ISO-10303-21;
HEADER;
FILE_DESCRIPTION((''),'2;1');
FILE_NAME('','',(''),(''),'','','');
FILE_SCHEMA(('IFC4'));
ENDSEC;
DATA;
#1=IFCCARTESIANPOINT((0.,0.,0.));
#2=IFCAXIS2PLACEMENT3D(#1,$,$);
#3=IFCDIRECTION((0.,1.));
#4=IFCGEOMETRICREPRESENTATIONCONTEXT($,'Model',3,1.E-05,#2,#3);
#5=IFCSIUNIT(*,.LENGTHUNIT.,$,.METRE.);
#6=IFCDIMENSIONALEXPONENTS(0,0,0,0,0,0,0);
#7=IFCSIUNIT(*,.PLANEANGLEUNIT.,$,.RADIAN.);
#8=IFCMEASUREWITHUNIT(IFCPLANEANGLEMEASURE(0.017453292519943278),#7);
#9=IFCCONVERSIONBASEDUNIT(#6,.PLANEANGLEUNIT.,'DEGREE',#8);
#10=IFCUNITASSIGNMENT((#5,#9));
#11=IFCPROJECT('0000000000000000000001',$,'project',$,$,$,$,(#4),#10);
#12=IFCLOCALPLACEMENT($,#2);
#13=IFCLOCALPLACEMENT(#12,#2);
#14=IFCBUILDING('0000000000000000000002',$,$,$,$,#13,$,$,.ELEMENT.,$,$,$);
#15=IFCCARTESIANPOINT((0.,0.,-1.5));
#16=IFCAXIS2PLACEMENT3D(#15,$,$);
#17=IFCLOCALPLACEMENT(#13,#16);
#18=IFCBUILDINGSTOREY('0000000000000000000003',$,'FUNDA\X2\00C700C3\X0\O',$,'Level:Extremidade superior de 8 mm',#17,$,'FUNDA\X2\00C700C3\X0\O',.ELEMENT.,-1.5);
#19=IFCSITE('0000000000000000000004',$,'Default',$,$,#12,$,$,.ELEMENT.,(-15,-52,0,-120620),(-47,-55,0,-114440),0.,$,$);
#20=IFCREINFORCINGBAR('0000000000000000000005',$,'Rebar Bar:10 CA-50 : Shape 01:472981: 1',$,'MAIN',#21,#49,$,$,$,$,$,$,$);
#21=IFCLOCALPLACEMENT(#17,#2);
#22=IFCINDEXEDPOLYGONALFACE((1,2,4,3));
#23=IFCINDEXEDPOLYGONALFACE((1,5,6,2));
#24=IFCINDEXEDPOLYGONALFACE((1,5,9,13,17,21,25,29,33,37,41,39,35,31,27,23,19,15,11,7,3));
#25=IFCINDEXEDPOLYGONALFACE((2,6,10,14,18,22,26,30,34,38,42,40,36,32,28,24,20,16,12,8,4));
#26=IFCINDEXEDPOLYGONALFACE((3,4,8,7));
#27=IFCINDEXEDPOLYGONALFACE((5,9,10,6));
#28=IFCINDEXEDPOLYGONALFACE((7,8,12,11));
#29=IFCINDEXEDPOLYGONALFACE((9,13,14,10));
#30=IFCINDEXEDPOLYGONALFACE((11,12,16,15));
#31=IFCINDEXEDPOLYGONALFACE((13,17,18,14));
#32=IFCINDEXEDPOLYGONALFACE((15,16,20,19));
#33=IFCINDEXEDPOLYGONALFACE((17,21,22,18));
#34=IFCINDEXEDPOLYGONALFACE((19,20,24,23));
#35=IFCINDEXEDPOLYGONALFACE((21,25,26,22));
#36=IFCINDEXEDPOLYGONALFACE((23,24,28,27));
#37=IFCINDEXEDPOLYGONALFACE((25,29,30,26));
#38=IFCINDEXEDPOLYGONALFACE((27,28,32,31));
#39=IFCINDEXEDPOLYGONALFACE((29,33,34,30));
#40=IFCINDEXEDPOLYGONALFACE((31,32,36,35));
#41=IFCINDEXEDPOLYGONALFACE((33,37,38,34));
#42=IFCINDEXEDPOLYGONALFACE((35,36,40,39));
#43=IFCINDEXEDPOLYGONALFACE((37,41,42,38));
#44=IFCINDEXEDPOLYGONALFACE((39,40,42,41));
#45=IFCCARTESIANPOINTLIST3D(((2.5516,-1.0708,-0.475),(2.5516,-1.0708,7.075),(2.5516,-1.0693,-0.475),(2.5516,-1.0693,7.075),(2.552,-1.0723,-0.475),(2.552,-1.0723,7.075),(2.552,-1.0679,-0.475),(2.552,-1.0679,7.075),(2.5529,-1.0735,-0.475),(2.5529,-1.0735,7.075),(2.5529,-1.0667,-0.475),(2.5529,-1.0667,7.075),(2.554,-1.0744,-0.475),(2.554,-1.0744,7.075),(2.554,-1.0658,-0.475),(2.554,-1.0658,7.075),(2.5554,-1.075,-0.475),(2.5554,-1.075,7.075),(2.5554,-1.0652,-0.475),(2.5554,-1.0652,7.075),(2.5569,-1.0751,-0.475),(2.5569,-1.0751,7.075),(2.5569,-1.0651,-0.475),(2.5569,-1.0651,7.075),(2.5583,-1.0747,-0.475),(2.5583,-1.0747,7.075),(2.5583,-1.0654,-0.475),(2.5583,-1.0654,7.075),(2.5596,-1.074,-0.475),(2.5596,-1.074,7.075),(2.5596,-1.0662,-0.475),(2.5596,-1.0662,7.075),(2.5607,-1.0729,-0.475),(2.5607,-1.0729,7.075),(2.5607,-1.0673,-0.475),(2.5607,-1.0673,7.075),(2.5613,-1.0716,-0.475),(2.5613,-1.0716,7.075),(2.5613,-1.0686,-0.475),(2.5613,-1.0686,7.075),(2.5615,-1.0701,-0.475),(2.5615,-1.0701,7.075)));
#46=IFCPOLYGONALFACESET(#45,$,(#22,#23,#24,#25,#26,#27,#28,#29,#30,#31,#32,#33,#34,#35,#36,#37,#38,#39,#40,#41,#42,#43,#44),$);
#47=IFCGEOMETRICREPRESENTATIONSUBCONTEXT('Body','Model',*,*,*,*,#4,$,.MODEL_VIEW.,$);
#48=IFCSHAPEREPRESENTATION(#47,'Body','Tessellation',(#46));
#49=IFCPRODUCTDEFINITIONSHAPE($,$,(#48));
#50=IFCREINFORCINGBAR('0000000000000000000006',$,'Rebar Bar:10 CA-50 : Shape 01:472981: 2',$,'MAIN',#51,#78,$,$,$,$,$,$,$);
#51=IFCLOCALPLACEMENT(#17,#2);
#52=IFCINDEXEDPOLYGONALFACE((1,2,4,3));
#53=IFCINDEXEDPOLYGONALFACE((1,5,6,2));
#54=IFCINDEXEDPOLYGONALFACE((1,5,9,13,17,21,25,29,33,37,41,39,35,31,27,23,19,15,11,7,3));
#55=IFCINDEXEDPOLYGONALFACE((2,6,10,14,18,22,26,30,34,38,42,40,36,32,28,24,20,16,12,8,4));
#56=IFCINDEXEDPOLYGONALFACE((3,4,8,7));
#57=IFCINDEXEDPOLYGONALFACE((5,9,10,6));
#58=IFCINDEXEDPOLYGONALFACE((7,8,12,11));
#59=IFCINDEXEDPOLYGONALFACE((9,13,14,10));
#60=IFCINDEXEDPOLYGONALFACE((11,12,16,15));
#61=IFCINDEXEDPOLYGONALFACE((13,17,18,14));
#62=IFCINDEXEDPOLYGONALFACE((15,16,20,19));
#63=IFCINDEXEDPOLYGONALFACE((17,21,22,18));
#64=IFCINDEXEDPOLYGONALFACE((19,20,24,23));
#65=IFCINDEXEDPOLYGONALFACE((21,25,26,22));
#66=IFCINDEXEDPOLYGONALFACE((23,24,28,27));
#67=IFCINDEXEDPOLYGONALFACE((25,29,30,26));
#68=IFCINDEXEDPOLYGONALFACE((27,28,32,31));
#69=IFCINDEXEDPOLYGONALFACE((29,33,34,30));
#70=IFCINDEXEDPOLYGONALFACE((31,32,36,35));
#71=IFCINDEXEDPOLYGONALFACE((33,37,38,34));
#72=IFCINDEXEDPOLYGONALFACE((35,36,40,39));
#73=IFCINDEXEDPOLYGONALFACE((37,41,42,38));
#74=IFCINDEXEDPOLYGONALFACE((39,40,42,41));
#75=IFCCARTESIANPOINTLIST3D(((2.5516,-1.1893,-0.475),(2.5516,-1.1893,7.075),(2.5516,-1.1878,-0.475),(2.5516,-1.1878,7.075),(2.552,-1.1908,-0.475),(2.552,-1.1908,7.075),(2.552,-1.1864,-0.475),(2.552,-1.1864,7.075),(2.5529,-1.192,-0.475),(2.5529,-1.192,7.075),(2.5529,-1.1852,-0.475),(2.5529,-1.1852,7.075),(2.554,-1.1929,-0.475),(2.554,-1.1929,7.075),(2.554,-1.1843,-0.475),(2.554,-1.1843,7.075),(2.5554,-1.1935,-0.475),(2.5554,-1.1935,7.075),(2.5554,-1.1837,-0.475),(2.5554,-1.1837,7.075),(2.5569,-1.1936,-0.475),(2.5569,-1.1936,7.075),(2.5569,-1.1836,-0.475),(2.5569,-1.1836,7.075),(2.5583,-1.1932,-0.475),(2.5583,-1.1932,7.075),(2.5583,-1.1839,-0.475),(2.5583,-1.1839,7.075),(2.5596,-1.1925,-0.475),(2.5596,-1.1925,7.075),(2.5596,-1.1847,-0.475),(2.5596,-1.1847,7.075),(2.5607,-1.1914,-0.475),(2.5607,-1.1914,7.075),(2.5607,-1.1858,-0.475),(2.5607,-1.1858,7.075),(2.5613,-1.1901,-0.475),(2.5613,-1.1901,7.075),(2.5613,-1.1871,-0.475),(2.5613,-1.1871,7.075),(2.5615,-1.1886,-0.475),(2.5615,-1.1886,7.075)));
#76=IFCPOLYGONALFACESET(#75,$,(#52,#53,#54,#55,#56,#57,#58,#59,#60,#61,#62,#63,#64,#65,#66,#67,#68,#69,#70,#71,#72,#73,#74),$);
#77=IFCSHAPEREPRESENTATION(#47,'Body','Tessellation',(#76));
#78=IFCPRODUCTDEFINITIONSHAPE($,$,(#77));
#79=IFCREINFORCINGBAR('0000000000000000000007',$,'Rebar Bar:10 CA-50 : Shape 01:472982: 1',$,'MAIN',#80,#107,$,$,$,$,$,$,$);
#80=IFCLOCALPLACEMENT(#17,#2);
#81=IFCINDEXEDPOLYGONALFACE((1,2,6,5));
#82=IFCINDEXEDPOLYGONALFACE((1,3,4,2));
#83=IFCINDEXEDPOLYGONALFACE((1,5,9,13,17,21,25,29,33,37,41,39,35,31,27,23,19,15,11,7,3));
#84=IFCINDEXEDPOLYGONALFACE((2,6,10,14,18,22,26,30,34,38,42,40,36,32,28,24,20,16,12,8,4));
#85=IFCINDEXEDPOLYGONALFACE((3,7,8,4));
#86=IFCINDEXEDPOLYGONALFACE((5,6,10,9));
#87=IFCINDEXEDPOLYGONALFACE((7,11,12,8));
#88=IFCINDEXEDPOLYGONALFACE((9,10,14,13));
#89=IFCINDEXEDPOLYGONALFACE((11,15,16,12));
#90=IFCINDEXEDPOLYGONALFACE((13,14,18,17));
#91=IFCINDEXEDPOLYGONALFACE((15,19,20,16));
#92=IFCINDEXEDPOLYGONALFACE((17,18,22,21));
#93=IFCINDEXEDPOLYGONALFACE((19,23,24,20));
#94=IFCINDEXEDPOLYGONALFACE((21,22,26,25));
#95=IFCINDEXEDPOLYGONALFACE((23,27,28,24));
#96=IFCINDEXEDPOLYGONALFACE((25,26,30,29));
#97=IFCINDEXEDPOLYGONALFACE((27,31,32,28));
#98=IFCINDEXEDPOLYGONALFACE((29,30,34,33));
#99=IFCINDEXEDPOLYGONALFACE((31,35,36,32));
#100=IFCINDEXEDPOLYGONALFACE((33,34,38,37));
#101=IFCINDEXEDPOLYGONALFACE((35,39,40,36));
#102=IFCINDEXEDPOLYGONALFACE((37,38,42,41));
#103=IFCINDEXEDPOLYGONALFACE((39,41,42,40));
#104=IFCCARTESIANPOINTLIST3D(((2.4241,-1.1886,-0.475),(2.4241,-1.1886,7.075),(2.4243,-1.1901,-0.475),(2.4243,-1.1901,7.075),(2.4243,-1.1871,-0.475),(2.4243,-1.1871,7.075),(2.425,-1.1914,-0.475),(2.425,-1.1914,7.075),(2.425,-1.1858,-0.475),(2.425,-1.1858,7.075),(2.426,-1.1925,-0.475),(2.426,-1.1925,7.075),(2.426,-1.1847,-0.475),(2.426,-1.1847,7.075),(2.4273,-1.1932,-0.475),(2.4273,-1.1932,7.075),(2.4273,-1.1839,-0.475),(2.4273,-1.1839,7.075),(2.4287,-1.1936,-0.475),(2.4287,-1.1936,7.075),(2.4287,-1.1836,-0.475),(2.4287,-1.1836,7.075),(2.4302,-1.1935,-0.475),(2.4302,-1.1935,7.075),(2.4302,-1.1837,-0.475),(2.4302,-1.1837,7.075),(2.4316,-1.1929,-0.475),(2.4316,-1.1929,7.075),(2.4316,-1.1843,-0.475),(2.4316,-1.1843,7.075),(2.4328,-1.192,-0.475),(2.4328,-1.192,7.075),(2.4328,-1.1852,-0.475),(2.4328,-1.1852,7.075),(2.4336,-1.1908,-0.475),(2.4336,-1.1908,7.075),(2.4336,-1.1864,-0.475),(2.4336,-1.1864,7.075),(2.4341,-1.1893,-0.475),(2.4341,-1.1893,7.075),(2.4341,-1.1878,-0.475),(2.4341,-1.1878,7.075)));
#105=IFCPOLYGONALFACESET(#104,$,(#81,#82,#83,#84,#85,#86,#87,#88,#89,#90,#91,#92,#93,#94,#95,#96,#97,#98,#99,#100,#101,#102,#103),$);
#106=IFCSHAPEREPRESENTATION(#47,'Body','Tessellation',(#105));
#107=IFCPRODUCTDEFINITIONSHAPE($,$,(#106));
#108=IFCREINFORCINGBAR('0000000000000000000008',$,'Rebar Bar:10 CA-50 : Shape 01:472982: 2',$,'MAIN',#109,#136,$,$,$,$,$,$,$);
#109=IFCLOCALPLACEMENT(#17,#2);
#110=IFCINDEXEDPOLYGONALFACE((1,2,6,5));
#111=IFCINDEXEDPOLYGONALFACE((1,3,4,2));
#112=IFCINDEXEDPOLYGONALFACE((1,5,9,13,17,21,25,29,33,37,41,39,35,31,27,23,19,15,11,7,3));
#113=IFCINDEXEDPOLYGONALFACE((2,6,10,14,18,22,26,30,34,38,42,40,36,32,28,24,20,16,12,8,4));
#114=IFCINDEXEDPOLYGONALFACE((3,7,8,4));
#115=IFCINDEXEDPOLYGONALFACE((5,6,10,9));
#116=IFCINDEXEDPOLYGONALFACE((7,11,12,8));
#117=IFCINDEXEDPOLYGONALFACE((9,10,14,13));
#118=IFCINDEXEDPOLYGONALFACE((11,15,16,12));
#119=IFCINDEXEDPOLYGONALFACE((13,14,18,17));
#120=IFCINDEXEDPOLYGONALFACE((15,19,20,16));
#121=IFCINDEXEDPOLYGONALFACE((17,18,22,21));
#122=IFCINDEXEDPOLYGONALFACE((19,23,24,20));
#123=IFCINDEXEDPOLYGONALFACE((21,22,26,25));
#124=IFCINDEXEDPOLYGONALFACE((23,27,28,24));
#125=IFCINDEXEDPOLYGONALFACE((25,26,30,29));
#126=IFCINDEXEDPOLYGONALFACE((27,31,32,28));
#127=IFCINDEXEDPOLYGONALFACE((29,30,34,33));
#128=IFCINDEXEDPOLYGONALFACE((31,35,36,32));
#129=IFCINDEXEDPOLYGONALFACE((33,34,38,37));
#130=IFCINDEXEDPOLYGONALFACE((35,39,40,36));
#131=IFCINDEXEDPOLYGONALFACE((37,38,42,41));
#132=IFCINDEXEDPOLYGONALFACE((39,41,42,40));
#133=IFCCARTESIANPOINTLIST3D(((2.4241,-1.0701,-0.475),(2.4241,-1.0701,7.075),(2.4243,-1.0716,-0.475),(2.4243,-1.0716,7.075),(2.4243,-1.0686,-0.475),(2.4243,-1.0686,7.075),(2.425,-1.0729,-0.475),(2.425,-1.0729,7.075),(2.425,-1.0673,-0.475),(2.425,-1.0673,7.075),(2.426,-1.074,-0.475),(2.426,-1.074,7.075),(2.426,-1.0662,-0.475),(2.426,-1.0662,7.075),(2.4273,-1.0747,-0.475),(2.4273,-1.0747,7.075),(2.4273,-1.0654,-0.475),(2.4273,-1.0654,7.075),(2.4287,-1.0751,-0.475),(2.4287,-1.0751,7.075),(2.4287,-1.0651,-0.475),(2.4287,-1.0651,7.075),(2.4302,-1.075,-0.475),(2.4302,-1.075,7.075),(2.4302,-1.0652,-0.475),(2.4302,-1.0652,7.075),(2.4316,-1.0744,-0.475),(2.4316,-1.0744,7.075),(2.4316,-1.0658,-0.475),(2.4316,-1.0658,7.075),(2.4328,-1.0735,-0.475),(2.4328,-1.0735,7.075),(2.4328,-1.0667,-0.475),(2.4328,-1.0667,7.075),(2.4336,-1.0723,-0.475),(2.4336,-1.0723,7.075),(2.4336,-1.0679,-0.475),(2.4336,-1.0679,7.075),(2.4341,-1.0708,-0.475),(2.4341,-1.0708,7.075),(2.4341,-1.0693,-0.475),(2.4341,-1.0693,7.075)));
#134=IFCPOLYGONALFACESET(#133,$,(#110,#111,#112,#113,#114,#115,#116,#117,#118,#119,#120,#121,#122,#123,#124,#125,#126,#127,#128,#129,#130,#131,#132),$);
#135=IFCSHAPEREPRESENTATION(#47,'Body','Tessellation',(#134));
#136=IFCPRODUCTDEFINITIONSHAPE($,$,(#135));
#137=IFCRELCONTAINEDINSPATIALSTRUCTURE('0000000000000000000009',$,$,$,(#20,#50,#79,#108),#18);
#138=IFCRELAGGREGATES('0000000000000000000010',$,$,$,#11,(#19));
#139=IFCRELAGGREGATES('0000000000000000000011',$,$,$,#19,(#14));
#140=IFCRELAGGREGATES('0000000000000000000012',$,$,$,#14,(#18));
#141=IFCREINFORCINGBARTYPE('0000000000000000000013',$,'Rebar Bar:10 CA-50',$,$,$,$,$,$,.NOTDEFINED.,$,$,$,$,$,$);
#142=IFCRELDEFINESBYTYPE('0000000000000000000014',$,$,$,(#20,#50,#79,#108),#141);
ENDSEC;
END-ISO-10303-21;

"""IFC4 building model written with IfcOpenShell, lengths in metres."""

from ifc_helpers import new_model, entity, si_unit, converted_unit, direction, frame, origin, place, context, subcontext, project, spatial, type_object, element, save


model = new_model("IFC4")

# Units and contexts
model_context = context("Model", 3, precision=1e-05, world=origin(), true_north=direction((0.0, 1.0)))
body_context = subcontext(model_context, "Body", "Model", "MODEL_VIEW")
ifc_project = project(units=[si_unit("LENGTHUNIT", "METRE"), converted_unit("PLANEANGLEUNIT", "DEGREE", entity("IfcPlaneAngleMeasure", 0.017453292519943278), si_unit("PLANEANGLEUNIT", "RADIAN"), dimensions=[0, 0, 0, 0, 0, 0, 0])], contexts=[model_context])

# Site, building, storey
site_placement = place(None, origin())
site = spatial("IfcSite", under=ifc_project, at=site_placement, Name="Default", CompositionType="ELEMENT", RefLatitude=(-15, -52, 0, -120620), RefLongitude=(-47, -55, 0, -114440), RefElevation=0.0)
building_placement = place(site_placement, origin())
building = spatial("IfcBuilding", under=site, at=building_placement, CompositionType="ELEMENT")
storey_placement = place(building_placement, frame((0.0, 0.0, -1.5)))
storey = spatial("IfcBuildingStorey", under=building, at=storey_placement, Name="FUNDAÇÃO", ObjectType="Level:Extremidade superior de 8 mm", LongName="FUNDAÇÃO", CompositionType="ELEMENT", Elevation=-1.5)

# Reinforcing bars
reinforcing_bar_type_1 = type_object("IfcReinforcingBarType", Name="Rebar Bar:10 CA-50", PredefinedType="NOTDEFINED")
reinforcing_bar_1_placement = place(storey_placement, origin())
element("IfcReinforcingBar", 1, at=reinforcing_bar_1_placement, inside=storey, type_object=reinforcing_bar_type_1, Name="Rebar Bar:10 CA-50 : Shape 01:472981: 1", ObjectType="MAIN", context=body_context, shape_type="AdvancedSweptSolid", body=[
    entity("IfcSweptDiskSolid", entity("IfcIndexedPolyCurve", entity("IfcCartesianPointList3D", [[2.5565, -1.0701, -0.475], [2.5565, -1.0701, 7.075]]), None, False), 0.005, None, 0.0, 1.0),
])
reinforcing_bar_2_placement = place(storey_placement, origin())
element("IfcReinforcingBar", 2, at=reinforcing_bar_2_placement, inside=storey, type_object=reinforcing_bar_type_1, Name="Rebar Bar:10 CA-50 : Shape 01:472981: 2", ObjectType="MAIN", context=body_context, shape_type="AdvancedSweptSolid", body=[
    entity("IfcSweptDiskSolid", entity("IfcIndexedPolyCurve", entity("IfcCartesianPointList3D", [[2.5565, -1.1886, -0.475], [2.5565, -1.1886, 7.075]]), None, False), 0.005, None, 0.0, 1.0),
])
reinforcing_bar_3_placement = place(storey_placement, origin())
element("IfcReinforcingBar", 3, at=reinforcing_bar_3_placement, inside=storey, type_object=reinforcing_bar_type_1, Name="Rebar Bar:10 CA-50 : Shape 01:472982: 1", ObjectType="MAIN", context=body_context, shape_type="AdvancedSweptSolid", body=[
    entity("IfcSweptDiskSolid", entity("IfcIndexedPolyCurve", entity("IfcCartesianPointList3D", [[2.4291, -1.1886, 7.075], [2.4291, -1.1886, -0.475]]), None, False), 0.005, None, 0.0, 1.0),
])
reinforcing_bar_4_placement = place(storey_placement, origin())
element("IfcReinforcingBar", 4, at=reinforcing_bar_4_placement, inside=storey, type_object=reinforcing_bar_type_1, Name="Rebar Bar:10 CA-50 : Shape 01:472982: 2", ObjectType="MAIN", context=body_context, shape_type="AdvancedSweptSolid", body=[
    entity("IfcSweptDiskSolid", entity("IfcIndexedPolyCurve", entity("IfcCartesianPointList3D", [[2.4291, -1.0701, 7.075], [2.4291, -1.0701, -0.475]]), None, False), 0.005, None, 0.0, 1.0),
])

save(model, "model.ifc")
